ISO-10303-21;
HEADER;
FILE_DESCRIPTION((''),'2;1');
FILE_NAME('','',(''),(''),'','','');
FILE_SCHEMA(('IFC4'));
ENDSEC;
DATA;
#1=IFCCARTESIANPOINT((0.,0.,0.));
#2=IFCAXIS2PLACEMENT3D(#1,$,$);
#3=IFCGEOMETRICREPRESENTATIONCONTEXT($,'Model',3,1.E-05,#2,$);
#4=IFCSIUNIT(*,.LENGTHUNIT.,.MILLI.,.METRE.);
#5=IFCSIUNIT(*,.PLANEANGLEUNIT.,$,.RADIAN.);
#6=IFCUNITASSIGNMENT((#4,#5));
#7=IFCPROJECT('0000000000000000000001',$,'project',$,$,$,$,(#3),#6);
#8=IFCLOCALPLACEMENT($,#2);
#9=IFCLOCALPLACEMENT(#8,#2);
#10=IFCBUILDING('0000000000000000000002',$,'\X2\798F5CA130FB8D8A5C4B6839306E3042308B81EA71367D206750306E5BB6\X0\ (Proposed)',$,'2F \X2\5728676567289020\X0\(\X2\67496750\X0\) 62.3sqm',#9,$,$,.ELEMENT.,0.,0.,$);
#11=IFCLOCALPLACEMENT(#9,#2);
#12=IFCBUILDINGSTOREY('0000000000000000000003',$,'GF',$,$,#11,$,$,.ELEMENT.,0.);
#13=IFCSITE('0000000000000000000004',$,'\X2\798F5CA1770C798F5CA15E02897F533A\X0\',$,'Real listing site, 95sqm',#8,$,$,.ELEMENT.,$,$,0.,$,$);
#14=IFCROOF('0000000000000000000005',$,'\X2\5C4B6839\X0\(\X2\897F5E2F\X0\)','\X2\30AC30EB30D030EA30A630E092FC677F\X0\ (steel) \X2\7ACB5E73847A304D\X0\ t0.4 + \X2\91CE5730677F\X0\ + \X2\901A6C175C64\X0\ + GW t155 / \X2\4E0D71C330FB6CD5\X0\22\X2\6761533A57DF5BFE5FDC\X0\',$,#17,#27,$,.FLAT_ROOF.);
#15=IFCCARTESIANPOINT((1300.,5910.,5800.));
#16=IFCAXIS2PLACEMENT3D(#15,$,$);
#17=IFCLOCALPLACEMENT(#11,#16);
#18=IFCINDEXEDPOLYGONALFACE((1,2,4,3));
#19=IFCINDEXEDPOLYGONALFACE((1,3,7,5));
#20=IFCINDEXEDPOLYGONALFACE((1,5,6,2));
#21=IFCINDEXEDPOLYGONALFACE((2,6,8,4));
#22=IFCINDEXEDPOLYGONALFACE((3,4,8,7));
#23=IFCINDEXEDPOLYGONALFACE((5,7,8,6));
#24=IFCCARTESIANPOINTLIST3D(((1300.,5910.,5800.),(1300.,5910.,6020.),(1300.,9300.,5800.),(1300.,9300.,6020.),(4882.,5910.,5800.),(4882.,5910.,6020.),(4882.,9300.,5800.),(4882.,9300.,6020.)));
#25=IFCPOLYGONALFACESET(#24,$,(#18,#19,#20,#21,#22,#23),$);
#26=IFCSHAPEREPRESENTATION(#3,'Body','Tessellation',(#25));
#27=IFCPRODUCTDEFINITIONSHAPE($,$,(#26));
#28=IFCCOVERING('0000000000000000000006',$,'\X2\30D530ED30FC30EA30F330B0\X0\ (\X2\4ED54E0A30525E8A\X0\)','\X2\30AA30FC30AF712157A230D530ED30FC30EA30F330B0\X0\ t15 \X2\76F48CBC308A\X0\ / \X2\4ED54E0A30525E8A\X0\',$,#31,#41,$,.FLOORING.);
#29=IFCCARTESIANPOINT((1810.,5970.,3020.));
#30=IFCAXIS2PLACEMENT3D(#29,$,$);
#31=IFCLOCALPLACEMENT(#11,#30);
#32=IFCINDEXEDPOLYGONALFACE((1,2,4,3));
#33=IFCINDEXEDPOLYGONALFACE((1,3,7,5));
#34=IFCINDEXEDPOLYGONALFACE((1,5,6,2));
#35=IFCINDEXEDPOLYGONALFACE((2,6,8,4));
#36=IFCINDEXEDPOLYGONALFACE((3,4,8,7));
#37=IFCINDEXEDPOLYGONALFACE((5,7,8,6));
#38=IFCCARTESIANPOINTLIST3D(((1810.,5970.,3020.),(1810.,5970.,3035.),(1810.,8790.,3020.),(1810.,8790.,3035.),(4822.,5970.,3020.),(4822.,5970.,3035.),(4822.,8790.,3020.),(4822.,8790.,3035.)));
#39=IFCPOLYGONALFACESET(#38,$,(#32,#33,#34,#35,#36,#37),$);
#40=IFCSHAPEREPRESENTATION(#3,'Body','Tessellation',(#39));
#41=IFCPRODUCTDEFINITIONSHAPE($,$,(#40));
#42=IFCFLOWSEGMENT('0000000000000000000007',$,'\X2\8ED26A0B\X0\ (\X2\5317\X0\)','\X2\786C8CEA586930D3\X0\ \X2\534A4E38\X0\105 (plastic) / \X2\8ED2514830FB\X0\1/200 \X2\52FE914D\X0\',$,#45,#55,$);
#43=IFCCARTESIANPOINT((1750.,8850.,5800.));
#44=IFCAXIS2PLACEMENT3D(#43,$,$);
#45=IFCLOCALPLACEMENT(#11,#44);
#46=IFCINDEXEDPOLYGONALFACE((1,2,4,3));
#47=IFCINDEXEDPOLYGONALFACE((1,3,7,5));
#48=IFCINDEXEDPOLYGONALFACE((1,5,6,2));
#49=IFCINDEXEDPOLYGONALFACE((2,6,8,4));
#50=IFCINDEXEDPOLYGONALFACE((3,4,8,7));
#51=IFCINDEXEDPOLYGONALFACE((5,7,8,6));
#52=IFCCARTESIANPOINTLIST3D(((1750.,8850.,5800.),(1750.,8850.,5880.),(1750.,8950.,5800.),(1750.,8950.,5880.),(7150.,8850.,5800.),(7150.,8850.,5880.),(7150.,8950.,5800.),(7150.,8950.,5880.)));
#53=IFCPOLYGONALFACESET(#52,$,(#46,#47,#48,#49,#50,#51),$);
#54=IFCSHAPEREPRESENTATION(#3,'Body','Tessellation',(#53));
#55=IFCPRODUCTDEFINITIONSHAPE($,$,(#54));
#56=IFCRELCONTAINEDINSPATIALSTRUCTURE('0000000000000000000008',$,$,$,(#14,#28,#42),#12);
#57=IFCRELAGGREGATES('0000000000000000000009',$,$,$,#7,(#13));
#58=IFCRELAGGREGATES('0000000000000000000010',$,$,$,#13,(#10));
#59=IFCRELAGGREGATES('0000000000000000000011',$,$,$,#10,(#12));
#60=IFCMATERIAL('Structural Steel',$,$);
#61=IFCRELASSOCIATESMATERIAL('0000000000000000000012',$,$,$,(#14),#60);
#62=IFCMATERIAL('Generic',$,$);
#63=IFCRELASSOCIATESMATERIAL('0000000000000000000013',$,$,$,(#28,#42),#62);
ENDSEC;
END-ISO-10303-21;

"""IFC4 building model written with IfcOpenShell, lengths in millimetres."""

from ifc_helpers import new_model, si_unit, frame, frame_2d, origin, place, context, project, spatial, rectangle, extrude, material, element, save


model = new_model("IFC4")

# Units and contexts
model_context = context("Model", 3, precision=1e-05, world=origin())
ifc_project = project(units=[si_unit("LENGTHUNIT", "METRE", prefix="MILLI"), si_unit("PLANEANGLEUNIT", "RADIAN")], contexts=[model_context])

# Site, building, storey
site_placement = place(None, origin())
site = spatial("IfcSite", under=ifc_project, at=site_placement, Name="福岡県福岡市西区", ObjectType="Real listing site, 95sqm", CompositionType="ELEMENT", RefElevation=0.0)
building_placement = place(site_placement, origin())
building = spatial("IfcBuilding", under=site, at=building_placement, Name="福岡・越屋根のある自然素材の家 (Proposed)", ObjectType="2F 在来木造(杉材) 62.3sqm", CompositionType="ELEMENT", ElevationOfRefHeight=0.0, ElevationOfTerrain=0.0)
storey_placement = place(building_placement, origin())
storey = spatial("IfcBuildingStorey", under=building, at=storey_placement, Name="GF", CompositionType="ELEMENT", Elevation=0.0)

# Roof
ifc_material_1 = material(Name="Structural Steel")
for number, where, name in (
    (1, (1300.0, 5910.0, 5800.0), "屋根(西帯)"),
):
    element("IfcRoof", number, at=place(storey_placement, frame(where)), inside=storey, material=ifc_material_1, Name=name, Description="ガルバリウム鋼板 (steel) 立平葺き t0.4 + 野地板 + 通気層 + GW t155 / 不燃・法22条区域対応", PredefinedType="FLAT_ROOF", context=model_context, shape_type="SweptSolid", body=[
        extrude(rectangle(XDim=3582.0, YDim=3390.0, at=frame_2d((1791.0, 1695.0))), frame((1300.0, 5910.0, 5800.0)), (0.0, 0.0, 1.0), 220.0),
    ])

# Covering
ifc_material_2 = material(Name="Generic")
covering_placement = place(storey_placement, frame((1810.0, 5970.0, 3020.0)))
element("IfcCovering", 2, at=covering_placement, inside=storey, material=ifc_material_2, Name="フローリング (仕上げ床)", Description="オーク無垢フローリング t15 直貼り / 仕上げ床", PredefinedType="FLOORING", context=model_context, shape_type="SweptSolid", body=[
    extrude(rectangle(XDim=3012.0, YDim=2820.0, at=frame_2d((1506.0, 1410.0))), frame((1810.0, 5970.0, 3020.0)), (0.0, 0.0, 1.0), 15.0),
])

# Flow segment
flow_segment_placement = place(storey_placement, frame((1750.0, 8850.0, 5800.0)))
element("IfcFlowSegment", 3, at=flow_segment_placement, inside=storey, material=ifc_material_2, Name="軒樋 (北)", Description="硬質塩ビ 半丸105 (plastic) / 軒先・1/200 勾配", context=model_context, shape_type="SweptSolid", body=[
    extrude(rectangle(XDim=5400.0, YDim=100.0, at=frame_2d((2700.0, 50.0))), frame((1750.0, 8850.0, 5800.0)), (0.0, 0.0, 1.0), 80.0),
])

save(model, "model.ifc")
